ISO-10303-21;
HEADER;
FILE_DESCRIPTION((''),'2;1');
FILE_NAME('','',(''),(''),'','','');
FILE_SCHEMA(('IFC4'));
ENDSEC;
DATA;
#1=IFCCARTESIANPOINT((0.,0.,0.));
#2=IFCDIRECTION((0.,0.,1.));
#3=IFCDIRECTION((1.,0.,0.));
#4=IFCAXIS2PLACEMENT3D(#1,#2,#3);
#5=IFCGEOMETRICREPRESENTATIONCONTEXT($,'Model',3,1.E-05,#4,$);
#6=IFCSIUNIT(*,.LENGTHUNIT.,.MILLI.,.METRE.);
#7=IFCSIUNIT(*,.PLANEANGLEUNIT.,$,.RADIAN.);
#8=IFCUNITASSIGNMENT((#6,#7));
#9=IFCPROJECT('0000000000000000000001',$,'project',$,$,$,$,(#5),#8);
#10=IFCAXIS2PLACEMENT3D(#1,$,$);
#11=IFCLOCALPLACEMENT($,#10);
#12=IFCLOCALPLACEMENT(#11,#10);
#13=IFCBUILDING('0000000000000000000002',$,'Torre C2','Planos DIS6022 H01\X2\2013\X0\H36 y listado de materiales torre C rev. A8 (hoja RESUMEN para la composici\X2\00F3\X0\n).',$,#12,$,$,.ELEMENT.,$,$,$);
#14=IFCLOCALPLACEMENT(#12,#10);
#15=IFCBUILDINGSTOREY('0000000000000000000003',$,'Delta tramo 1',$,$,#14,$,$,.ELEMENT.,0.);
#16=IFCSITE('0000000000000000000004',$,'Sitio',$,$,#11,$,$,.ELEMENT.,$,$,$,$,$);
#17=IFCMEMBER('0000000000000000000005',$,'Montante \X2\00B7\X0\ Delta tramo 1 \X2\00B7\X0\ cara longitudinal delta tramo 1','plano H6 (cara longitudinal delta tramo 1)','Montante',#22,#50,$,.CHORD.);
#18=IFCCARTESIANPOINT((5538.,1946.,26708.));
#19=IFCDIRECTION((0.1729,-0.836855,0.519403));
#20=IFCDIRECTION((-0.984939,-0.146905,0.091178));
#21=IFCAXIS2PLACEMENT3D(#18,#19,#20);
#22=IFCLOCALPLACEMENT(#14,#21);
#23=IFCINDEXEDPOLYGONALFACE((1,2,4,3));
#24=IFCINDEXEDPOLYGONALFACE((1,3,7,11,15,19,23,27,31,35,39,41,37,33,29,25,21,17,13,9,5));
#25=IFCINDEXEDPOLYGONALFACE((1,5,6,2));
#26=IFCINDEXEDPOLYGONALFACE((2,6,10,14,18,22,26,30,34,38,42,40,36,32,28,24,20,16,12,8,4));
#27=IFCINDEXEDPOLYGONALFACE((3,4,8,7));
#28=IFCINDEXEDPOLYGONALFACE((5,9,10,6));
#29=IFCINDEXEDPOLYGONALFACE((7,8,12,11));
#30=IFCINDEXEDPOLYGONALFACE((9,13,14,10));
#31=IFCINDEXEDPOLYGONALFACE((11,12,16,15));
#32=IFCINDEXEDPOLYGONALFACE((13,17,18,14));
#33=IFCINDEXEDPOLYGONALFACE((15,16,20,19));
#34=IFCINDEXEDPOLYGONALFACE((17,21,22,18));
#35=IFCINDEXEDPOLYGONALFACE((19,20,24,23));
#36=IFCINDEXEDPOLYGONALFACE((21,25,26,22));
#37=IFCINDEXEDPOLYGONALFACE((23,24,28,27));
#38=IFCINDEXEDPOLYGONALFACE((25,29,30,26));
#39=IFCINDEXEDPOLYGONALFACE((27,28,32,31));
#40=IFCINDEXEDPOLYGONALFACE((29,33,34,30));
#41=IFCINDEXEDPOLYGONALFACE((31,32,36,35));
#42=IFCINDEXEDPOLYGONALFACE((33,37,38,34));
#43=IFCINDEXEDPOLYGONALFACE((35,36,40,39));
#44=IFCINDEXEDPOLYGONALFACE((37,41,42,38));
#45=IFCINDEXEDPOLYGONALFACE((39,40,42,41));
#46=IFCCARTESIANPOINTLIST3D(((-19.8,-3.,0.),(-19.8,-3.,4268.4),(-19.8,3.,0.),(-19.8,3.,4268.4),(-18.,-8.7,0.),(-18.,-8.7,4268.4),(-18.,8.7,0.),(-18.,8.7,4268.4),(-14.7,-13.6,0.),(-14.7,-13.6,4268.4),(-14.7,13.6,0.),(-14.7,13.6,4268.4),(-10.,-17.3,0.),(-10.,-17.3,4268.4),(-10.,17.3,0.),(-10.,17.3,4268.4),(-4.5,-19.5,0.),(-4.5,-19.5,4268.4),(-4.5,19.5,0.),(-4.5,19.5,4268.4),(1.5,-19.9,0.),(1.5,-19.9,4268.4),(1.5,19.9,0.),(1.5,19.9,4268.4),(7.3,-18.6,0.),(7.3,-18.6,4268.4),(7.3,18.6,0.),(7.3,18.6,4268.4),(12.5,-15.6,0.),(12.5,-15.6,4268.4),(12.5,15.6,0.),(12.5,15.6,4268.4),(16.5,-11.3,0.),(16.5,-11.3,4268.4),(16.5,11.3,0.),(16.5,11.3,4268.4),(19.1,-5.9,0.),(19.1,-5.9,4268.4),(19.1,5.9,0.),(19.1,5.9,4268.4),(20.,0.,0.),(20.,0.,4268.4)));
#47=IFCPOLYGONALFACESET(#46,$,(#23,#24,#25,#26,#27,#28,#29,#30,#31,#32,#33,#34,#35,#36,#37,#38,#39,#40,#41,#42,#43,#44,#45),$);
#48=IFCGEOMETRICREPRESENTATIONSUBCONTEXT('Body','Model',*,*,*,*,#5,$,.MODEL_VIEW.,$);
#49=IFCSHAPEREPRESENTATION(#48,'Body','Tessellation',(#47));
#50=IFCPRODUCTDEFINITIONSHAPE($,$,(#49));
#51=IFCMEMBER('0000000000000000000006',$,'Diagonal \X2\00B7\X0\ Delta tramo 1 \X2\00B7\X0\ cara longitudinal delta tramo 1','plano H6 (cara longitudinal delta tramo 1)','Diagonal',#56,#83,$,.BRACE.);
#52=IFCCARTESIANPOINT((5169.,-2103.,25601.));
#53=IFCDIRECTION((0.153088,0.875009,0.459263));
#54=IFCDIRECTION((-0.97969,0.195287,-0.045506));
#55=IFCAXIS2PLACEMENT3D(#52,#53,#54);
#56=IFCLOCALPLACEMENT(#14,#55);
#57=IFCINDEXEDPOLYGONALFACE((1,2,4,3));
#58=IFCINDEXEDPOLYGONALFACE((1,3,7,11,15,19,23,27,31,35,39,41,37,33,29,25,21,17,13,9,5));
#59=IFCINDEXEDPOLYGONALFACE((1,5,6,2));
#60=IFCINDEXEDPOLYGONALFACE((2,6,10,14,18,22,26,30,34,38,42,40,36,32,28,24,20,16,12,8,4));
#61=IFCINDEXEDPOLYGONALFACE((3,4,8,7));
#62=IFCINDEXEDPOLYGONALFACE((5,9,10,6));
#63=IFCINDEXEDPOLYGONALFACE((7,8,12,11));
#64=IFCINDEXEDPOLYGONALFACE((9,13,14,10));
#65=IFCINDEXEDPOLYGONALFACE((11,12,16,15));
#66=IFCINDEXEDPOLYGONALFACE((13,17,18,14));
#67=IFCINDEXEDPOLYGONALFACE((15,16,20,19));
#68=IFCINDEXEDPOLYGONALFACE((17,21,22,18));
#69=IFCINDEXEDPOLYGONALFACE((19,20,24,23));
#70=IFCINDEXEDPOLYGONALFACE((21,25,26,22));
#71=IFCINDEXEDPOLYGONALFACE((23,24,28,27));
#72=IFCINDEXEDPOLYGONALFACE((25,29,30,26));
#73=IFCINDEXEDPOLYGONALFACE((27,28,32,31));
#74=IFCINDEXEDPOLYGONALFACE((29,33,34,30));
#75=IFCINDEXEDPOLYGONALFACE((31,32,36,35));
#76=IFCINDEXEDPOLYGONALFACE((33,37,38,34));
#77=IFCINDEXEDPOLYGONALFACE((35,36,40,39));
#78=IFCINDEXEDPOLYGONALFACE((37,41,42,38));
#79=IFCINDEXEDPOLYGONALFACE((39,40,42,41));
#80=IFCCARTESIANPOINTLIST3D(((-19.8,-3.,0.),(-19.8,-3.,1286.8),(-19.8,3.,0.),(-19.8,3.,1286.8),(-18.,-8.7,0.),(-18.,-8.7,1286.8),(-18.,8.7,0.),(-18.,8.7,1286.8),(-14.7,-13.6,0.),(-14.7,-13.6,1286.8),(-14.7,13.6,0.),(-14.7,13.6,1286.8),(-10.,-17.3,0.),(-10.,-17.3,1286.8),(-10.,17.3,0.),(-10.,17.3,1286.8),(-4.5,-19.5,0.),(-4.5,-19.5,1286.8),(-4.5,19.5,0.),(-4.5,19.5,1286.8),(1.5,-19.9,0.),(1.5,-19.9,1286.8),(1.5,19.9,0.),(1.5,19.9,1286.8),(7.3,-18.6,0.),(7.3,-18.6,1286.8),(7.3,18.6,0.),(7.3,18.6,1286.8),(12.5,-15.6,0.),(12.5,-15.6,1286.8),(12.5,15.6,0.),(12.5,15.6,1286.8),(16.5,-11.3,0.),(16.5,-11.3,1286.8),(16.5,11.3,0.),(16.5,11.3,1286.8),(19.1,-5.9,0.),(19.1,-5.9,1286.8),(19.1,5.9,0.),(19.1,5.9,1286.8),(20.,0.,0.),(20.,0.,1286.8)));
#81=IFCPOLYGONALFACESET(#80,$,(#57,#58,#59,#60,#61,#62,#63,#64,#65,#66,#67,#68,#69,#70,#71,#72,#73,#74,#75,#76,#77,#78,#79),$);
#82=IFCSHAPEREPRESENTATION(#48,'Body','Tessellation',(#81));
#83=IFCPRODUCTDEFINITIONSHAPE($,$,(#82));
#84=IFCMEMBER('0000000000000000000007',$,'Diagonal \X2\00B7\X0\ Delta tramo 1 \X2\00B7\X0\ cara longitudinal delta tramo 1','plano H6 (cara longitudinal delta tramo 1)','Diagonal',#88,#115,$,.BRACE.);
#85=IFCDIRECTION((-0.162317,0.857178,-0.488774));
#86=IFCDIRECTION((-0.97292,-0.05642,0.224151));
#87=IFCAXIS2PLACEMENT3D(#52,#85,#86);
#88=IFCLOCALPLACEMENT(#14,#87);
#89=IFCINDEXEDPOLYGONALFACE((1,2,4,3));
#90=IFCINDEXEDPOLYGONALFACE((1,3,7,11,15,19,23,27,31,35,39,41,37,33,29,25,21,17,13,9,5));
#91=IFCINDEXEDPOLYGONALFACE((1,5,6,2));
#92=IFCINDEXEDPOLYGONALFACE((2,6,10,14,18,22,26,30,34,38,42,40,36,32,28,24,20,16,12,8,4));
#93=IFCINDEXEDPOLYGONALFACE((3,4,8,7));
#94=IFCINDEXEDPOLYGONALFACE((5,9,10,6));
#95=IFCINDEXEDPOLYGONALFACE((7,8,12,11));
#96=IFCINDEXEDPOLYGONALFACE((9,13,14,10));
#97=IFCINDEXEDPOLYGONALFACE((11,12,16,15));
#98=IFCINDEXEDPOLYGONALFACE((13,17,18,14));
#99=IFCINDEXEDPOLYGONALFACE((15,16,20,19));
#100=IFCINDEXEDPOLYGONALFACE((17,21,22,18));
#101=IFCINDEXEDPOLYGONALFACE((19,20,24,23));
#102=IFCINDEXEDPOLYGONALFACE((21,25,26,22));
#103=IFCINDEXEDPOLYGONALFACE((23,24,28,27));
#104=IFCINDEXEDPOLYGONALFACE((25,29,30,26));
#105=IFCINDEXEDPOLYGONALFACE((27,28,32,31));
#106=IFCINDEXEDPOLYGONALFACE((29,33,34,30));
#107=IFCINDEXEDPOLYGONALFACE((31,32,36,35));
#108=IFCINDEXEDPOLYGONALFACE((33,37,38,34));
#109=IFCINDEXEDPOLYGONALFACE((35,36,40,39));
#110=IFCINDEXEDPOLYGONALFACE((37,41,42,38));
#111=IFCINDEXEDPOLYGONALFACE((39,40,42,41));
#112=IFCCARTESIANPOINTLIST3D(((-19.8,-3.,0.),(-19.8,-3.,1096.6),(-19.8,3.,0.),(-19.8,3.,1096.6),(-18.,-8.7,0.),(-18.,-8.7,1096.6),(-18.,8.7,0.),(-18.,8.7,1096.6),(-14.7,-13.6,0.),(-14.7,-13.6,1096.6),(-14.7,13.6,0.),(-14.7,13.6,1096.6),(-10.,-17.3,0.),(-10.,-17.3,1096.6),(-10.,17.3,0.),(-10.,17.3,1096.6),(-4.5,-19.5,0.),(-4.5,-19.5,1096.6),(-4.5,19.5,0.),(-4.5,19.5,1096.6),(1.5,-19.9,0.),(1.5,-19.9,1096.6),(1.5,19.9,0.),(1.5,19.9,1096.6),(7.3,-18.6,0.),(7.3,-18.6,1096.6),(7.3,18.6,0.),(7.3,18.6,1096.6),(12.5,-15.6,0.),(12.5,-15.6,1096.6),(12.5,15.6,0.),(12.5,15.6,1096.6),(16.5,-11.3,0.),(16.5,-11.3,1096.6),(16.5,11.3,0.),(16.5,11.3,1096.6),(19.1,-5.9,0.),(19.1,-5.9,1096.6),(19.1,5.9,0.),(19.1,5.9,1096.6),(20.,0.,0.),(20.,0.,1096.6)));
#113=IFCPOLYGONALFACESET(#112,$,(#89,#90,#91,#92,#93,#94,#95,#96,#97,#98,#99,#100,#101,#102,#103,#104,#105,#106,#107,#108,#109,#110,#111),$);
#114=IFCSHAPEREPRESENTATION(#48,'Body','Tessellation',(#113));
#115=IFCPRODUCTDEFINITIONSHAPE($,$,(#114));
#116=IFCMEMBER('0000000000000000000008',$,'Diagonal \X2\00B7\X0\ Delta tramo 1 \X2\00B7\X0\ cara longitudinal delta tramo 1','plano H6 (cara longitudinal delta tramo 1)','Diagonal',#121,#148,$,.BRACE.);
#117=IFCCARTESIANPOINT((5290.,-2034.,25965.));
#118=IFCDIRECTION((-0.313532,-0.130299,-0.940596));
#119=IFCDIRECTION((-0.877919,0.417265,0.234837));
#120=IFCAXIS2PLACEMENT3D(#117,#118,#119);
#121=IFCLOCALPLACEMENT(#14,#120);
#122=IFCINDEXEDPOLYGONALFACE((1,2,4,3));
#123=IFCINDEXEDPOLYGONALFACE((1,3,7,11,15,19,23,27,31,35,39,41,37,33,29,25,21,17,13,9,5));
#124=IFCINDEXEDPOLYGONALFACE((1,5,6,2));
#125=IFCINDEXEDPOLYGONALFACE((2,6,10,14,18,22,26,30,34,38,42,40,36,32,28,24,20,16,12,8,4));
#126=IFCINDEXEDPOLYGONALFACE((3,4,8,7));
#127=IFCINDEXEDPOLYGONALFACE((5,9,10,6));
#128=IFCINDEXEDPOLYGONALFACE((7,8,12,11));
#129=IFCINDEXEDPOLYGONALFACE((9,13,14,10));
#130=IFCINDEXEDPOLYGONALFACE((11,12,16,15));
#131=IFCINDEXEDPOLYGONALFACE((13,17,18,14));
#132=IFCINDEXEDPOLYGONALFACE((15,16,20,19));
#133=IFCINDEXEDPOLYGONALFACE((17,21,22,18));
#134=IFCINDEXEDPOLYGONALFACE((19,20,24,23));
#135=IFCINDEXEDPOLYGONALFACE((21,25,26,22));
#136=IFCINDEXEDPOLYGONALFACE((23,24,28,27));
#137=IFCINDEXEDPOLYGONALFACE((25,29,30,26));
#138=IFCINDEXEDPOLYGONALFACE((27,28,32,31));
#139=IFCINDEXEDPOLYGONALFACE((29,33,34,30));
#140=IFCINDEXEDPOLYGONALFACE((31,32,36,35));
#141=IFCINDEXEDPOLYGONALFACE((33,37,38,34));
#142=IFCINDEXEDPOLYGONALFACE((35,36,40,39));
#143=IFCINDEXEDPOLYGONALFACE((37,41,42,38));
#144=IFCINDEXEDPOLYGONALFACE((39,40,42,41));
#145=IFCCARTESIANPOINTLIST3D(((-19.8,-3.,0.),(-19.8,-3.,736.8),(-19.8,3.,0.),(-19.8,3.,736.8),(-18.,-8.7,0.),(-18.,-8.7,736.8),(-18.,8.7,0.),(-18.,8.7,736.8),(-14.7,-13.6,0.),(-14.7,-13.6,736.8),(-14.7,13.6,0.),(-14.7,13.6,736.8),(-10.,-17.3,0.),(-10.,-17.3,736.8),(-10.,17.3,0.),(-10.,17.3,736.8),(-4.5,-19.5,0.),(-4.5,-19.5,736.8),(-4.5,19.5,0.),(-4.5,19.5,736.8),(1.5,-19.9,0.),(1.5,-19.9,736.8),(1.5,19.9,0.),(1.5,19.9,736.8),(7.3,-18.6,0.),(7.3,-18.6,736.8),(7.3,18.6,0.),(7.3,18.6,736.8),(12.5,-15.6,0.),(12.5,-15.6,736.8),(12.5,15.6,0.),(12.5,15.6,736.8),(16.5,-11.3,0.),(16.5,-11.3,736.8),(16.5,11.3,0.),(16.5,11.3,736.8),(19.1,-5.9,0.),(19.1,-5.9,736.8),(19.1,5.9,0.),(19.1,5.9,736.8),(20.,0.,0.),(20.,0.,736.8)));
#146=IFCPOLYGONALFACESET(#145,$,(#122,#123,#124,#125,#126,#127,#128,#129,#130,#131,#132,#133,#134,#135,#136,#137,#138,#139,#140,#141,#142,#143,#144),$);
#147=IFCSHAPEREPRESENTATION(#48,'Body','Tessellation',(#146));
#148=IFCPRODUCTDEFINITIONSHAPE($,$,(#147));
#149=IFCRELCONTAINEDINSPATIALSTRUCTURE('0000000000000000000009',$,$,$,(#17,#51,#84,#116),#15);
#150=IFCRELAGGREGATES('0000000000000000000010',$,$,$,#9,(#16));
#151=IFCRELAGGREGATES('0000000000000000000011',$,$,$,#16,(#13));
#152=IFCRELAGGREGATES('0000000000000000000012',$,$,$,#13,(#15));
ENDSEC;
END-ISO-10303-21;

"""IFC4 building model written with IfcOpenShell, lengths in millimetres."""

from ifc_helpers import new_model, si_unit, frame, origin, origin_with_axes, place, context, subcontext, project, spatial, circle, extrude, element, save


model = new_model("IFC4")

# Units and contexts
model_context = context("Model", 3, precision=1e-05, world=origin_with_axes())
body_context = subcontext(model_context, "Body", "Model", "MODEL_VIEW")
ifc_project = project(units=[si_unit("LENGTHUNIT", "METRE", prefix="MILLI"), si_unit("PLANEANGLEUNIT", "RADIAN")], contexts=[model_context])

# Site, building, storey
site_placement = place(None, origin())
site = spatial("IfcSite", under=ifc_project, at=site_placement, Name="Sitio", CompositionType="ELEMENT")
building_placement = place(site_placement, origin())
building = spatial("IfcBuilding", under=site, at=building_placement, Name="Torre C2", Description="Planos DIS6022 H01–H36 y listado de materiales torre C rev. A8 (hoja RESUMEN para la composición).", CompositionType="ELEMENT")
storey_placement = place(building_placement, origin())
storey = spatial("IfcBuildingStorey", under=building, at=storey_placement, Name="Delta tramo 1", CompositionType="ELEMENT", Elevation=0.0)

# Members
member_1_placement = place(storey_placement, frame((5538.0, 1946.0, 26708.0), z_axis=(0.1729, -0.836855, 0.519403), x_axis=(-0.984939, -0.146905, 0.091178)))
element("IfcMember", 1, at=member_1_placement, inside=storey, Name="Montante · Delta tramo 1 · cara longitudinal delta tramo 1", Description="plano H6 (cara longitudinal delta tramo 1)", ObjectType="Montante", PredefinedType="CHORD", context=body_context, shape_type="SweptSolid", body=[
    extrude(circle(Radius=20.0), None, (0.0, 0.0, 1.0), 4268.4),
])
member_2_placement = place(storey_placement, frame((5169.0, -2103.0, 25601.0), z_axis=(0.153088, 0.875009, 0.459263), x_axis=(-0.97969, 0.195287, -0.045506)))
element("IfcMember", 2, at=member_2_placement, inside=storey, Name="Diagonal · Delta tramo 1 · cara longitudinal delta tramo 1", Description="plano H6 (cara longitudinal delta tramo 1)", ObjectType="Diagonal", PredefinedType="BRACE", context=body_context, shape_type="SweptSolid", body=[
    extrude(circle(Radius=20.0), None, (0.0, 0.0, 1.0), 1286.8),
])
member_3_placement = place(storey_placement, frame((5169.0, -2103.0, 25601.0), z_axis=(-0.162317, 0.857178, -0.488774), x_axis=(-0.97292, -0.05642, 0.224151)))
element("IfcMember", 3, at=member_3_placement, inside=storey, Name="Diagonal · Delta tramo 1 · cara longitudinal delta tramo 1", Description="plano H6 (cara longitudinal delta tramo 1)", ObjectType="Diagonal", PredefinedType="BRACE", context=body_context, shape_type="SweptSolid", body=[
    extrude(circle(Radius=20.0), None, (0.0, 0.0, 1.0), 1096.6),
])
member_4_placement = place(storey_placement, frame((5290.0, -2034.0, 25965.0), z_axis=(-0.313532, -0.130299, -0.940596), x_axis=(-0.877919, 0.417265, 0.234837)))
element("IfcMember", 4, at=member_4_placement, inside=storey, Name="Diagonal · Delta tramo 1 · cara longitudinal delta tramo 1", Description="plano H6 (cara longitudinal delta tramo 1)", ObjectType="Diagonal", PredefinedType="BRACE", context=body_context, shape_type="SweptSolid", body=[
    extrude(circle(Radius=20.0), None, (0.0, 0.0, 1.0), 736.8),
])

save(model, "model.ifc")
